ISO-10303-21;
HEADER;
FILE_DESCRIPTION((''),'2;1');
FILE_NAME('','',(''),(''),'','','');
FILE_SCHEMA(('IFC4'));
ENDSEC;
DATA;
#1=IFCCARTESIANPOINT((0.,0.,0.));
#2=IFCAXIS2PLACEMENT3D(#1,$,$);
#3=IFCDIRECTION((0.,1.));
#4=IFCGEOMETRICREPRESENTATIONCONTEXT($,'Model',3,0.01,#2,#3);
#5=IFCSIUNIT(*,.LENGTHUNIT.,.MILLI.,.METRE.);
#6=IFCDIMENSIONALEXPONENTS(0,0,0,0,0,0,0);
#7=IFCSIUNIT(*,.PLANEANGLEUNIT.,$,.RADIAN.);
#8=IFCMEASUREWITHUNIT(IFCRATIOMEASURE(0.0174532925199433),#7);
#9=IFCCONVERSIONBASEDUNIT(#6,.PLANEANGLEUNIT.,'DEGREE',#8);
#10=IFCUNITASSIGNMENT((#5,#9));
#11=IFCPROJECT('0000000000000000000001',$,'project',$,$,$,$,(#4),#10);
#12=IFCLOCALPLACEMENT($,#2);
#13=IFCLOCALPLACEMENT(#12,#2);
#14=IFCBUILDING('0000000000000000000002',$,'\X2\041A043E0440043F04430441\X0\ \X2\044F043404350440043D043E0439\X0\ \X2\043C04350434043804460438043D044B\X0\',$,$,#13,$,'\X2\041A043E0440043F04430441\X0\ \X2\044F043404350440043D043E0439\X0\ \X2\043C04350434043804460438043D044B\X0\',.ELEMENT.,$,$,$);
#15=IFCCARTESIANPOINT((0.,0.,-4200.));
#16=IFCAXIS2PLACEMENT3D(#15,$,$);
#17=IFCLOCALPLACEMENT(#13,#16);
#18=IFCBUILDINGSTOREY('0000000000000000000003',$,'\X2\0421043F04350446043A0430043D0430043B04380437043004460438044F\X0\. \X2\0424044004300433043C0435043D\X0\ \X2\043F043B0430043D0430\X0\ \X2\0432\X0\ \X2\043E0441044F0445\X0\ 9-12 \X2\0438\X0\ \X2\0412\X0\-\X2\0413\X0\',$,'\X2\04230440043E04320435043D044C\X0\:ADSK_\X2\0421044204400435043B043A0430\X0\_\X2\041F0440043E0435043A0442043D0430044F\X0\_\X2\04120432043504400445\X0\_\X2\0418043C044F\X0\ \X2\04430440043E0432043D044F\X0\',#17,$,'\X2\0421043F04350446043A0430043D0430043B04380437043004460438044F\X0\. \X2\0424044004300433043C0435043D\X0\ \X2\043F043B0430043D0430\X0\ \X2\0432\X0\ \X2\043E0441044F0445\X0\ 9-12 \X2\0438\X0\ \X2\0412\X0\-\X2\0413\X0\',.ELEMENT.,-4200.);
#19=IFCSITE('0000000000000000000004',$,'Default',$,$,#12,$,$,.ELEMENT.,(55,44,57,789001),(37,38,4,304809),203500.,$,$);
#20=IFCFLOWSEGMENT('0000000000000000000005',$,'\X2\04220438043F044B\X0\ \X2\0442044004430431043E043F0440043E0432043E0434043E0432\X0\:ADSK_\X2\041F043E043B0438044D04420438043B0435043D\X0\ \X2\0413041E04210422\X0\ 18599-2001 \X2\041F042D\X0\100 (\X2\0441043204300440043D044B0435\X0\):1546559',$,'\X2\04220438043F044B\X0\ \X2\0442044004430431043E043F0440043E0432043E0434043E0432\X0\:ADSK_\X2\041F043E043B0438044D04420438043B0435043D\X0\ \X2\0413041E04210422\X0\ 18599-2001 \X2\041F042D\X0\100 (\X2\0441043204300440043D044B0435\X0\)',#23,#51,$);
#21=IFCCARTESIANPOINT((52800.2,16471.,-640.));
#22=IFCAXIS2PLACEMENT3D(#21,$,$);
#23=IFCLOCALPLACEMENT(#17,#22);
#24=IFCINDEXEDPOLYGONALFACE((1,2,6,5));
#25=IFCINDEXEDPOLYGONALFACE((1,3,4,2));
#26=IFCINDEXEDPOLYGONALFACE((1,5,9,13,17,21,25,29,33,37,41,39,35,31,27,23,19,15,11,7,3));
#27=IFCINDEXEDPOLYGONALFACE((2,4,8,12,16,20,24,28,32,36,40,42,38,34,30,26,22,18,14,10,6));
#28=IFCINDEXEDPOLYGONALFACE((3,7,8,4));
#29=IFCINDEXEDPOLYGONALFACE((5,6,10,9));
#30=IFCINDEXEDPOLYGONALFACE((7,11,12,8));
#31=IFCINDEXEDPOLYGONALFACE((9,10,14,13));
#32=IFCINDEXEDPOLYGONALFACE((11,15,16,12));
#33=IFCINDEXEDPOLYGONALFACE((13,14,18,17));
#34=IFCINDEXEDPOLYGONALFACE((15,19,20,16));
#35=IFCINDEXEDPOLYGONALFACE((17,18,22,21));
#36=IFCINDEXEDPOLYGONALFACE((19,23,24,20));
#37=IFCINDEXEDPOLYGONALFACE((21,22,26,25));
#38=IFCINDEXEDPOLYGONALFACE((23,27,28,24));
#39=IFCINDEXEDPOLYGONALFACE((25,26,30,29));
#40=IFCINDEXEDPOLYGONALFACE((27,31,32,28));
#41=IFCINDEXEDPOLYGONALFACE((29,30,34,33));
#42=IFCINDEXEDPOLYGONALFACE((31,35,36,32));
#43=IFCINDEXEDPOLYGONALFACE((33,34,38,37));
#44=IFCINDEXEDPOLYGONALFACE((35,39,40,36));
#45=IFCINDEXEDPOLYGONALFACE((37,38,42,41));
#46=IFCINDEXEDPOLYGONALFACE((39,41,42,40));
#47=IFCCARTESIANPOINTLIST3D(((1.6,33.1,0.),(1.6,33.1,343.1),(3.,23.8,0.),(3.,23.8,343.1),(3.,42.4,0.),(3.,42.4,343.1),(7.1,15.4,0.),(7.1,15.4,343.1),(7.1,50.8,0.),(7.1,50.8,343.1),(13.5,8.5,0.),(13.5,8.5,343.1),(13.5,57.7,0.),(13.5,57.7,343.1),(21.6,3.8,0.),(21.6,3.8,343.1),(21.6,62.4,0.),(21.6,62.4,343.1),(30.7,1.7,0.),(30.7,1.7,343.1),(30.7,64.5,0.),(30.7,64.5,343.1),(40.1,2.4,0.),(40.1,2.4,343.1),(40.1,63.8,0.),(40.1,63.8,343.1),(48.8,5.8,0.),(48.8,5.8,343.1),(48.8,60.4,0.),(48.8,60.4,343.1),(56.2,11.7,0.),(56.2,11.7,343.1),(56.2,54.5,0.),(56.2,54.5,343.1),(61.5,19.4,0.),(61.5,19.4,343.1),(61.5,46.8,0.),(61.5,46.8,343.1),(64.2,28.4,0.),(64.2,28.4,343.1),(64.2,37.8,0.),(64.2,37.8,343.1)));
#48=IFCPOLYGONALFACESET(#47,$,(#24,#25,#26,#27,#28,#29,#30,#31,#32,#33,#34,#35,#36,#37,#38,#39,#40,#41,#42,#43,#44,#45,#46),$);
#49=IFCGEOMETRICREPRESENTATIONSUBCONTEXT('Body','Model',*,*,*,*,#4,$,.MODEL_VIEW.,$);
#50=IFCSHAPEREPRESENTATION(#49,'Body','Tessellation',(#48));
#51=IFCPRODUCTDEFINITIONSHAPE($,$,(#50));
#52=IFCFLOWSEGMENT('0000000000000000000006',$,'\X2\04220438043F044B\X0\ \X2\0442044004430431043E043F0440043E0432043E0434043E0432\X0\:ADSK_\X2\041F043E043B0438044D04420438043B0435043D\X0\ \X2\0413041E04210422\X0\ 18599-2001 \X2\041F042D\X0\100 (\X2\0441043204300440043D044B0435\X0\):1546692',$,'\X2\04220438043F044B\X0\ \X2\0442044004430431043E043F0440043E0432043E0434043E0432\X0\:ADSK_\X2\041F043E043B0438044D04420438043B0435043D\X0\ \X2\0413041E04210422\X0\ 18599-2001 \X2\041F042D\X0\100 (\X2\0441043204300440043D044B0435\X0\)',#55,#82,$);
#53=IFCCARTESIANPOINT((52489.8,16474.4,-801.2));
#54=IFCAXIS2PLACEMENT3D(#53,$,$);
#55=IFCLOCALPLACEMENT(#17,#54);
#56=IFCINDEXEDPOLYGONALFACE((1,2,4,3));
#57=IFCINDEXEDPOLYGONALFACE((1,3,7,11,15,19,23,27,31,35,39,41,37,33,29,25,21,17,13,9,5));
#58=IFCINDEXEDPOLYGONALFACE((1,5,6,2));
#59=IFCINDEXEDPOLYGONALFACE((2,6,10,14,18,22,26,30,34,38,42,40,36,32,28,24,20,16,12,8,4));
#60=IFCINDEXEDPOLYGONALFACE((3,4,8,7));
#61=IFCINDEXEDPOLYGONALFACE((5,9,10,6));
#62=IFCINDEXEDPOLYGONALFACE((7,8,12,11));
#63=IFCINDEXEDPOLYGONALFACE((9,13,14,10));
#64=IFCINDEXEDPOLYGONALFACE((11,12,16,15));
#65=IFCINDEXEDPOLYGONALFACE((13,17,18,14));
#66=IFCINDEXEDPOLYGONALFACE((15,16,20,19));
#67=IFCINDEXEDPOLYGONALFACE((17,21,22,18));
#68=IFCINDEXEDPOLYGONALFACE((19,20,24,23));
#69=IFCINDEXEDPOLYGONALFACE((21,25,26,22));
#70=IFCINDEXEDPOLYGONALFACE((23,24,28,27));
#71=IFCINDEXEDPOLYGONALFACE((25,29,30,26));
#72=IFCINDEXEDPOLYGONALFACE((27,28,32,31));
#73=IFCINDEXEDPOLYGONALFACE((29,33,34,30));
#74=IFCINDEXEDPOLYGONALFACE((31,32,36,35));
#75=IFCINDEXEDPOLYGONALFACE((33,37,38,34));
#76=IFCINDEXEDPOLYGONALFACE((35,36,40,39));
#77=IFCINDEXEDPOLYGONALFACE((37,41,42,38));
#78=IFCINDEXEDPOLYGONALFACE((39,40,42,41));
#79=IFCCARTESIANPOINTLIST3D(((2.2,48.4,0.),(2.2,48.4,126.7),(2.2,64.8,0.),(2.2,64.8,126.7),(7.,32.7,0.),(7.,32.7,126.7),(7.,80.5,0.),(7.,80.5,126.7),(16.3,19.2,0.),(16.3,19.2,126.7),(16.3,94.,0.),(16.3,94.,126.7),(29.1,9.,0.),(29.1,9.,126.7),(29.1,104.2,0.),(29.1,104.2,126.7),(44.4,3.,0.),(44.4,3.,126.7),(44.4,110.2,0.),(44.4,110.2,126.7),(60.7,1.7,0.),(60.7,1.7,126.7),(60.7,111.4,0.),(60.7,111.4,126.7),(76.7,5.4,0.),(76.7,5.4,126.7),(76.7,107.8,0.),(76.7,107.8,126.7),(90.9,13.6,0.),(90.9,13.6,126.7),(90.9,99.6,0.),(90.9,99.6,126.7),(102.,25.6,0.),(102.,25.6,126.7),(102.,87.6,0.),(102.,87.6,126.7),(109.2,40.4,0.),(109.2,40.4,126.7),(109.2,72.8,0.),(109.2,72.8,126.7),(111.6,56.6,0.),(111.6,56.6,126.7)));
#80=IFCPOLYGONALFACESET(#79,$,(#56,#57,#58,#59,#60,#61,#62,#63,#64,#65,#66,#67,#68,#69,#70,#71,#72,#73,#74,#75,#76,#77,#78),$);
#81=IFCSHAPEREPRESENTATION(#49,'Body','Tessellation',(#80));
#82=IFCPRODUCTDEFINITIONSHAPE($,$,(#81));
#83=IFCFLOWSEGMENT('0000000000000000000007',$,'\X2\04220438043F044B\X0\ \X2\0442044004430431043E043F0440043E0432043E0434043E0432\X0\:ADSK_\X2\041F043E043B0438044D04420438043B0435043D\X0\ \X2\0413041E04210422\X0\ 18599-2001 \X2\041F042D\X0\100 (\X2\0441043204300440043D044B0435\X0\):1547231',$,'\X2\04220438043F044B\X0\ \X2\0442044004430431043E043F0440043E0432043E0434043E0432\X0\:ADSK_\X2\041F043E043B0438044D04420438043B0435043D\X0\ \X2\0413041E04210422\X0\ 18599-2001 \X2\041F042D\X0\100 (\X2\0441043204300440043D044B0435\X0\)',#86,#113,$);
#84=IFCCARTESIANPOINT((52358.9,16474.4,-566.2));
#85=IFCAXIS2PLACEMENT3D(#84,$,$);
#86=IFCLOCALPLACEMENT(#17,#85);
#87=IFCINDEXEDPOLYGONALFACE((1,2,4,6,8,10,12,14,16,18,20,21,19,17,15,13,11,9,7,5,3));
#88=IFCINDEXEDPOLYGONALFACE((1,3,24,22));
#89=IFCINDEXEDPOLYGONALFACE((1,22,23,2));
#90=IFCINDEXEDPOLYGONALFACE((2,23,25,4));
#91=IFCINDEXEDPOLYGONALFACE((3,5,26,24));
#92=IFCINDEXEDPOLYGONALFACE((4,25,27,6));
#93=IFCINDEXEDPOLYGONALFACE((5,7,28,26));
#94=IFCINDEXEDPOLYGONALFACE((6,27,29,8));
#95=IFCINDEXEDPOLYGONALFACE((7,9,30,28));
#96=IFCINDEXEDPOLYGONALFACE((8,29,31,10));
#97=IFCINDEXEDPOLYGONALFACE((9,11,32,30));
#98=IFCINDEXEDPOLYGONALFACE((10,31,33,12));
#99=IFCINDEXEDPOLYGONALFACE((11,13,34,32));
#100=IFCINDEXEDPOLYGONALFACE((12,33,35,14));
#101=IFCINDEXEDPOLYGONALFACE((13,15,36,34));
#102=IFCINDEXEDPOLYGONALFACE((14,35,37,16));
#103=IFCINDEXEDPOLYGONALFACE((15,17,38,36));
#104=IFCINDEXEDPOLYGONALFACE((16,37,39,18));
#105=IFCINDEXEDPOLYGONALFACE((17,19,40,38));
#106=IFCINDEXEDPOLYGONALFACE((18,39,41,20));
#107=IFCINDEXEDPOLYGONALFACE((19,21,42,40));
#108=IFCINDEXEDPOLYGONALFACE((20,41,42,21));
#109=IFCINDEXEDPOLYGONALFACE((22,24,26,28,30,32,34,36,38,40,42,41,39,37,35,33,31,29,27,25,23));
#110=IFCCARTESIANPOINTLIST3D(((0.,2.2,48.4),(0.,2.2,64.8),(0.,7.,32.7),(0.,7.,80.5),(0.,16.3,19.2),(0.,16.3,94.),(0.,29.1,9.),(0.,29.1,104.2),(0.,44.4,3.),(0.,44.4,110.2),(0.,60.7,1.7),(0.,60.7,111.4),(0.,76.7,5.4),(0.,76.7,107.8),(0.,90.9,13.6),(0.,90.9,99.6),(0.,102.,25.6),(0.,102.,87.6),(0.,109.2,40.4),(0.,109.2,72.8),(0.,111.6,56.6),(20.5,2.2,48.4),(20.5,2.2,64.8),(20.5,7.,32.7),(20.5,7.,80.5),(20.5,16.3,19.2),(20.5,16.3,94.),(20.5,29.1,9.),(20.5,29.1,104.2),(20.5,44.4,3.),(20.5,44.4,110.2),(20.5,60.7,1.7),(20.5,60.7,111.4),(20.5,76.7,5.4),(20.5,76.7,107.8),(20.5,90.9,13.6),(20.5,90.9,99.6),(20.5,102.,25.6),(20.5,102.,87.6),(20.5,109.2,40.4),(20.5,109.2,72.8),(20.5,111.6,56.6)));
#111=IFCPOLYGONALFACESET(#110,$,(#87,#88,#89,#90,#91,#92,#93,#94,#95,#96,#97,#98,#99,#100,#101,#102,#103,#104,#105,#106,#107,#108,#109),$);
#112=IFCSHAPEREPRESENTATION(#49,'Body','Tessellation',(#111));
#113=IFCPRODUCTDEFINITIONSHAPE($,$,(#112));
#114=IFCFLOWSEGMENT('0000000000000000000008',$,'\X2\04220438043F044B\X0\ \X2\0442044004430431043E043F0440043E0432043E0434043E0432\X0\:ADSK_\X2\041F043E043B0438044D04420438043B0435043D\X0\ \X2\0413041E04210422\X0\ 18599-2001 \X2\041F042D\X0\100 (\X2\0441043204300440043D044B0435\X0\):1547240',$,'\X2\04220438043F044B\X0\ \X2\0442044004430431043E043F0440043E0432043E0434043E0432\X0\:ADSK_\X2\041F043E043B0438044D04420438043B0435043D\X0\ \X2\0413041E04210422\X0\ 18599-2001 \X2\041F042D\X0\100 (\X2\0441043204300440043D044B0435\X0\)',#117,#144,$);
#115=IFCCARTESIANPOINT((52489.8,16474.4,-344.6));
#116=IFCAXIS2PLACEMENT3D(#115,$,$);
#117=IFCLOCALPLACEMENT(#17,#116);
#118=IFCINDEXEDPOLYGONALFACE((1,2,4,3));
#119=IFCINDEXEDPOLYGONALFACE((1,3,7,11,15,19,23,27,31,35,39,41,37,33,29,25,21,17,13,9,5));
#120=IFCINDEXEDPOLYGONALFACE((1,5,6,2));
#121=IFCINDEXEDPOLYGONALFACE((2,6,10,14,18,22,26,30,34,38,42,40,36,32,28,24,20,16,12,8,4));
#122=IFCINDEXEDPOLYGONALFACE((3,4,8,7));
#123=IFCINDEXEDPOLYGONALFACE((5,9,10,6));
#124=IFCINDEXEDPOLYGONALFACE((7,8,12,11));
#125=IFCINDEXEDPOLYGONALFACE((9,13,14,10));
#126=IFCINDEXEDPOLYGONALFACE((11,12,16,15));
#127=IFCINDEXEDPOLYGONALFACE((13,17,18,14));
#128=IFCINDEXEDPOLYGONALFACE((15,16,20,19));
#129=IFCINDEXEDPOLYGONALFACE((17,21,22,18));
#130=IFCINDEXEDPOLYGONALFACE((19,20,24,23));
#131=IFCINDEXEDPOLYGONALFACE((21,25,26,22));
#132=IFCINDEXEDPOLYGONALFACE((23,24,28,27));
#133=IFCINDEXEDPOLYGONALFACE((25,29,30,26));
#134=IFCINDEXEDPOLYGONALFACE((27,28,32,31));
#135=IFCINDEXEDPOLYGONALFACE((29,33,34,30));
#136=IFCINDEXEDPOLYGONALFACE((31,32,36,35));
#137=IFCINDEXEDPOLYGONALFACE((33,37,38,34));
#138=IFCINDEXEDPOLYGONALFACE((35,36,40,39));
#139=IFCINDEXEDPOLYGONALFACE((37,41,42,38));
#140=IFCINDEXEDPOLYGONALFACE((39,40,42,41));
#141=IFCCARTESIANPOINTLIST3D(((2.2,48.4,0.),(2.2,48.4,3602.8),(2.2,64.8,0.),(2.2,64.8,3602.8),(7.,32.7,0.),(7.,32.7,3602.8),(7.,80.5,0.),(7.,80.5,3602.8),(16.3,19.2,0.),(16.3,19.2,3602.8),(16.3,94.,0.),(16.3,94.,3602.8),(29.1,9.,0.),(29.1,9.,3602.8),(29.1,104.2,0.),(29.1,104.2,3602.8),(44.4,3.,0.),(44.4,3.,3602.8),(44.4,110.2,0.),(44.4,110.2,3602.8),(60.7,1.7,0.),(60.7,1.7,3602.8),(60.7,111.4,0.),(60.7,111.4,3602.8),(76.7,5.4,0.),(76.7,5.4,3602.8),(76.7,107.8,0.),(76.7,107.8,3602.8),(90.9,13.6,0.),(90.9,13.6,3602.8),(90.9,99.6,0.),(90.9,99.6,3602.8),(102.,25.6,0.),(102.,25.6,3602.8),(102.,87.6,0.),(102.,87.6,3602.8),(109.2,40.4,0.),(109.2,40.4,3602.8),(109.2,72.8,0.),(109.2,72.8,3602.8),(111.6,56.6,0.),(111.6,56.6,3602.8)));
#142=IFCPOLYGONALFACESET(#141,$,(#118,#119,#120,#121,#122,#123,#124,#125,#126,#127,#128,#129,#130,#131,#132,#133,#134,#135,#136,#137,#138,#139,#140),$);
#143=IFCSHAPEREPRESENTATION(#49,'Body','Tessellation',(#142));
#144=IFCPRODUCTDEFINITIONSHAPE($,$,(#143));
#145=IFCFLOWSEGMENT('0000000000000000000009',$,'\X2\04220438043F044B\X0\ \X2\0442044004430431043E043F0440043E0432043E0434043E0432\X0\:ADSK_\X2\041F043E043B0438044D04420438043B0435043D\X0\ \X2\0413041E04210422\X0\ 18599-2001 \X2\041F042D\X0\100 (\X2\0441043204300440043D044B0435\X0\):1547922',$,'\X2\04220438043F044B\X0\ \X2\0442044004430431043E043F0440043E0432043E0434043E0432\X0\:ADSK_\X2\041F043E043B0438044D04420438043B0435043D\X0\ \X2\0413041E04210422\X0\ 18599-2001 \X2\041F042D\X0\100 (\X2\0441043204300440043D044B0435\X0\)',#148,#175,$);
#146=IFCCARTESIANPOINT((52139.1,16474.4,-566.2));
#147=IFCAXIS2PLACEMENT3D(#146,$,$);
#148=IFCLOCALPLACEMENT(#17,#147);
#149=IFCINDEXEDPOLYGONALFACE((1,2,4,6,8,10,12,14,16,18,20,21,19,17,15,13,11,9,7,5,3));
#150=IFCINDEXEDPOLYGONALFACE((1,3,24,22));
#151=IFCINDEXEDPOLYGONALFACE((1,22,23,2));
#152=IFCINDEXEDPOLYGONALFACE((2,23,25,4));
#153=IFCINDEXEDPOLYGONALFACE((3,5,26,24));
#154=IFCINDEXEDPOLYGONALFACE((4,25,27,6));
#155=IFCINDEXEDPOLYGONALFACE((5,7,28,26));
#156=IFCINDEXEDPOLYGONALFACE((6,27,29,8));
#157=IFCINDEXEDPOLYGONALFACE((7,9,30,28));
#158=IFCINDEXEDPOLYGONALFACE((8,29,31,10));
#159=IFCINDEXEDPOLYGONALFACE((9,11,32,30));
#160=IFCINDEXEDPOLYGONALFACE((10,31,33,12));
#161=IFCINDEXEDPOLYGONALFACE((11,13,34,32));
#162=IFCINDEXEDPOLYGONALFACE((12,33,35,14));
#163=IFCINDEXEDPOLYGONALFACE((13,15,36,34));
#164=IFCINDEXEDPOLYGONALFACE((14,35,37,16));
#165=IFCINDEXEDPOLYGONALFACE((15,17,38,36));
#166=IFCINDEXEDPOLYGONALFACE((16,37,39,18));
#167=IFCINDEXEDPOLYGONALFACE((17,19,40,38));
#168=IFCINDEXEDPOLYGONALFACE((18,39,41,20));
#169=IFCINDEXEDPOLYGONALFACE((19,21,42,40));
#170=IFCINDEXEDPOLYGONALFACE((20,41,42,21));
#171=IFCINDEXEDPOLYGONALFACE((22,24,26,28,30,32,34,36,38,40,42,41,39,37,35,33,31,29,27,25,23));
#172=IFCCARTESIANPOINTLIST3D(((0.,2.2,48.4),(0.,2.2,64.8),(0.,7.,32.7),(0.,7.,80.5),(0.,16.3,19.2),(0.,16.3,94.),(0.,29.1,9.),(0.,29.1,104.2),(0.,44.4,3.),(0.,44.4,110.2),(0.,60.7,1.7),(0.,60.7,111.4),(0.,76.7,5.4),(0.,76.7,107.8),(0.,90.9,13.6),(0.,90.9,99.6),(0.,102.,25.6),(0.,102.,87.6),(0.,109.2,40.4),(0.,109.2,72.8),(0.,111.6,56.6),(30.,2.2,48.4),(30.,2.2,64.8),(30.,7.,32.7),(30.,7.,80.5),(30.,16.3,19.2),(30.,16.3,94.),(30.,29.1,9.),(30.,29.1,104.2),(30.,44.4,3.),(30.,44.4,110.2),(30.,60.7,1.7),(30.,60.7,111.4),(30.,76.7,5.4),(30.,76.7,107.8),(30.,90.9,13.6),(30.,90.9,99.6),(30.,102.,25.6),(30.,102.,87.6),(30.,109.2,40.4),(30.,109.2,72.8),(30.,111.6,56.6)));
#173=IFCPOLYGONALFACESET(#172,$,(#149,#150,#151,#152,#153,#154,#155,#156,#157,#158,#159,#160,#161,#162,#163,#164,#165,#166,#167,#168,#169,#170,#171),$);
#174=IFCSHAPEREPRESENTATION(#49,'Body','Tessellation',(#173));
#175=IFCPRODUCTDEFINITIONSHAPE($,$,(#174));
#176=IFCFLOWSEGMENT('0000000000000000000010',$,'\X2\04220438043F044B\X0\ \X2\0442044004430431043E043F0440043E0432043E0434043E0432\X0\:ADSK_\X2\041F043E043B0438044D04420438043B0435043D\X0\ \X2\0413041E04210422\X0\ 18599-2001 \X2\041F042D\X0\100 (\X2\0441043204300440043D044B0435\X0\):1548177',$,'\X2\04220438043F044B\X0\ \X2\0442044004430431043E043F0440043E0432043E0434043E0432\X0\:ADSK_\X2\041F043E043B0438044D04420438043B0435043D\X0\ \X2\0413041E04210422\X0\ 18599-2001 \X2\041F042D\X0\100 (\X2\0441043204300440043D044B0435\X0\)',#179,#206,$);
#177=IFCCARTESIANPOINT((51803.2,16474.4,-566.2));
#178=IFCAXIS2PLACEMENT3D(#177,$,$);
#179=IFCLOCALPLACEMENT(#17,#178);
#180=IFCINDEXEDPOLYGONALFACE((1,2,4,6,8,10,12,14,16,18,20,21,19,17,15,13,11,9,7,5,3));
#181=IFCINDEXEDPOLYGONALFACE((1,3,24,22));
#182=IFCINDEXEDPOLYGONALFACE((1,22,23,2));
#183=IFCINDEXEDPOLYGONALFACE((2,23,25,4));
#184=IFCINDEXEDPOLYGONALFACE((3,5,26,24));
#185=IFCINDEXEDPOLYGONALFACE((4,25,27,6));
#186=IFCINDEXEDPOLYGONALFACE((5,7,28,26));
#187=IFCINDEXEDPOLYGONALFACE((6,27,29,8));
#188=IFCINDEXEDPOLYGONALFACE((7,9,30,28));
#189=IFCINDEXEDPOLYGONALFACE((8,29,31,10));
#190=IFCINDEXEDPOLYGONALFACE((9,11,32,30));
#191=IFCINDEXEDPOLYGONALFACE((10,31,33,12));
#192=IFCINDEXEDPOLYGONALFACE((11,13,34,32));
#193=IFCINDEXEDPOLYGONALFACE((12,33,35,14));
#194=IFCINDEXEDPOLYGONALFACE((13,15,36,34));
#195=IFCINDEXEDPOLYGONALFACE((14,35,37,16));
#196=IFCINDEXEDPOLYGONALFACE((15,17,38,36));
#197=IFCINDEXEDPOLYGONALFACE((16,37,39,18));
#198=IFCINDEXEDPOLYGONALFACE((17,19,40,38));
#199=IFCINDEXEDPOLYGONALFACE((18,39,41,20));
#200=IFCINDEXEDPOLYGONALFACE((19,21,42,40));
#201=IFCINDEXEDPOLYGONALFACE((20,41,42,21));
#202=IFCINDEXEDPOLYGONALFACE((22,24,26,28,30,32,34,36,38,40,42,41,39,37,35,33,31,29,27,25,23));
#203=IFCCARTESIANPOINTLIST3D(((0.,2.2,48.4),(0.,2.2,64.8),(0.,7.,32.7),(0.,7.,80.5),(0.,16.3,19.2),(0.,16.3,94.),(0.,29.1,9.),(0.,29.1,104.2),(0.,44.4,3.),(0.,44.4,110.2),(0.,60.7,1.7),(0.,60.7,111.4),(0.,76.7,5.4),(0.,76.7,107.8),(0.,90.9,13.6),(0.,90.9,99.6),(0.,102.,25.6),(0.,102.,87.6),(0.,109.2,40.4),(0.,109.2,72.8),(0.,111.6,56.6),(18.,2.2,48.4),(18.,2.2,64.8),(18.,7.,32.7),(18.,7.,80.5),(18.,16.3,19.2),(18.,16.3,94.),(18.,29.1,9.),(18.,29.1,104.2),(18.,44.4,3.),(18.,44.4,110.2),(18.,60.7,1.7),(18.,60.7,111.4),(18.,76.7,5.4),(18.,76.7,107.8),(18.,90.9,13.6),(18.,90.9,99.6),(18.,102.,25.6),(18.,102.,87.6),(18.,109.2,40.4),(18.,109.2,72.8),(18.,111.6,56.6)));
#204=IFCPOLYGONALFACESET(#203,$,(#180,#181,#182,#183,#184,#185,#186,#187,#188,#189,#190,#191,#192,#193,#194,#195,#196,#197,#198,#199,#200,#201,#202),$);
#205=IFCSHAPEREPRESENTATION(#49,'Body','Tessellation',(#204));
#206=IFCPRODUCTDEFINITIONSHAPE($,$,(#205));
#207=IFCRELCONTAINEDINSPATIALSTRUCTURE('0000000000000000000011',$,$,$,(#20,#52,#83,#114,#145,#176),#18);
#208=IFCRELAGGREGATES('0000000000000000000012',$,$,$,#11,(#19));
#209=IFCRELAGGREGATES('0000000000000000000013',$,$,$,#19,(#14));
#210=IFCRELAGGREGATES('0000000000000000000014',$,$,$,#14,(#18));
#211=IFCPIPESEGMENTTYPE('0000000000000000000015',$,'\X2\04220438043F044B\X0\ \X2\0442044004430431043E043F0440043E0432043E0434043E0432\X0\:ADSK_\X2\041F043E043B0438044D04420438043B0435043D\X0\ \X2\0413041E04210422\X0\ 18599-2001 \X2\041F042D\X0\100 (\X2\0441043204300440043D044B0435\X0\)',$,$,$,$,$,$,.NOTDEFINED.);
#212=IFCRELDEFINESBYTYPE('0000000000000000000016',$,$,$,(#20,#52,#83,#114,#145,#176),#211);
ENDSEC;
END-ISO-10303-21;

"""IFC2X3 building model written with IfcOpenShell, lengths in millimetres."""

from ifc_helpers import new_model, entity, si_unit, converted_unit, direction, frame, frame_2d, origin, origin_2d_with_axis, place, context, subcontext, project, spatial, circle, extrude, type_object, element, save


model = new_model("IFC2X3")

# Units and contexts
model_context = context("Model", 3, precision=0.01, world=origin(), true_north=direction((0.0, 1.0)))
body_context = subcontext(model_context, "Body", "Model", "MODEL_VIEW")
ifc_project = project(units=[si_unit("LENGTHUNIT", "METRE", prefix="MILLI"), converted_unit("PLANEANGLEUNIT", "DEGREE", entity("IfcRatioMeasure", 0.0174532925199433), si_unit("PLANEANGLEUNIT", "RADIAN"), dimensions=[0, 0, 0, 0, 0, 0, 0])], contexts=[model_context])

# Site, building, storey
site_placement = place(None, frame((0.0, 0.0, 0.0)))
site = spatial("IfcSite", under=ifc_project, at=site_placement, Name="Default", CompositionType="ELEMENT", RefLatitude=(55, 44, 57, 789001), RefLongitude=(37, 38, 4, 304809), RefElevation=203500.0)
building_placement = place(site_placement, origin())
building = spatial("IfcBuilding", under=site, at=building_placement, Name="Корпус ядерной медицины", LongName="Корпус ядерной медицины", CompositionType="ELEMENT")
storey_placement = place(building_placement, frame((0.0, 0.0, -4200.0)))
storey = spatial("IfcBuildingStorey", under=building, at=storey_placement, Name="Спецканализация. Фрагмен плана в осях 9-12 и В-Г", ObjectType="Уровень:ADSK_Стрелка_Проектная_Вверх_Имя уровня", LongName="Спецканализация. Фрагмен плана в осях 9-12 и В-Г", CompositionType="ELEMENT", Elevation=-4200.0)

# Flow segments
pipe_segment_type = type_object("IfcPipeSegmentType", Name="Типы трубопроводов:ADSK_Полиэтилен ГОСТ 18599-2001 ПЭ100 (сварные)", PredefinedType="NOTDEFINED")
flow_segment_1_placement = place(storey_placement, frame((52800.2, 16471.0, -640.0)))
element("IfcFlowSegment", 1, at=flow_segment_1_placement, inside=storey, type_object=pipe_segment_type, Name="Типы трубопроводов:ADSK_Полиэтилен ГОСТ 18599-2001 ПЭ100 (сварные):1546559", ObjectType="Типы трубопроводов:ADSK_Полиэтилен ГОСТ 18599-2001 ПЭ100 (сварные)", context=body_context, shape_type="SweptSolid", body=[
    extrude(circle(Radius=31.5, at=frame_2d((0.0, 0.0), x_axis=(1.0, 0.0))), frame((33.1, 33.1, 0.0), z_axis=(0.0, 0.0, 1.0), x_axis=(-1.0, 0.0, 0.0)), (0.0, 0.0, 1.0), 343.1),
])
flow_segment_2_placement = place(storey_placement, frame((52489.8, 16474.4, -801.2)))
element("IfcFlowSegment", 2, at=flow_segment_2_placement, inside=storey, type_object=pipe_segment_type, Name="Типы трубопроводов:ADSK_Полиэтилен ГОСТ 18599-2001 ПЭ100 (сварные):1546692", ObjectType="Типы трубопроводов:ADSK_Полиэтилен ГОСТ 18599-2001 ПЭ100 (сварные)", context=body_context, shape_type="SweptSolid", body=[
    extrude(circle(Radius=55.0, at=origin_2d_with_axis()), frame((56.6, 56.6, 0.0)), (0.0, 0.0, 1.0), 126.7),
])
flow_segment_3_placement = place(storey_placement, frame((52358.9, 16474.4, -566.2)))
element("IfcFlowSegment", 3, at=flow_segment_3_placement, inside=storey, type_object=pipe_segment_type, Name="Типы трубопроводов:ADSK_Полиэтилен ГОСТ 18599-2001 ПЭ100 (сварные):1547231", ObjectType="Типы трубопроводов:ADSK_Полиэтилен ГОСТ 18599-2001 ПЭ100 (сварные)", context=body_context, shape_type="SweptSolid", body=[
    extrude(circle(Radius=55.0, at=frame_2d((0.0, 0.0), x_axis=(1.0, 0.0))), frame((0.0, 56.6, 56.6), z_axis=(1.0, 0.0, 0.0), x_axis=(0.0, 1.0, 0.0)), (0.0, 0.0, 1.0), 20.5),
])
flow_segment_4_placement = place(storey_placement, frame((52489.8, 16474.4, -344.6)))
element("IfcFlowSegment", 4, at=flow_segment_4_placement, inside=storey, type_object=pipe_segment_type, Name="Типы трубопроводов:ADSK_Полиэтилен ГОСТ 18599-2001 ПЭ100 (сварные):1547240", ObjectType="Типы трубопроводов:ADSK_Полиэтилен ГОСТ 18599-2001 ПЭ100 (сварные)", context=body_context, shape_type="SweptSolid", body=[
    extrude(circle(Radius=55.0, at=origin_2d_with_axis()), frame((56.6, 56.6, 0.0)), (0.0, 0.0, 1.0), 3602.8),
])
flow_segment_5_placement = place(storey_placement, frame((52139.1, 16474.4, -566.2)))
element("IfcFlowSegment", 5, at=flow_segment_5_placement, inside=storey, type_object=pipe_segment_type, Name="Типы трубопроводов:ADSK_Полиэтилен ГОСТ 18599-2001 ПЭ100 (сварные):1547922", ObjectType="Типы трубопроводов:ADSK_Полиэтилен ГОСТ 18599-2001 ПЭ100 (сварные)", context=body_context, shape_type="SweptSolid", body=[
    extrude(circle(Radius=55.0, at=origin_2d_with_axis()), frame((0.0, 56.6, 56.6), z_axis=(1.0, 0.0, 0.0), x_axis=(0.0, 1.0, 0.0)), (0.0, 0.0, 1.0), 30.0),
])
flow_segment_6_placement = place(storey_placement, frame((51803.2, 16474.4, -566.2)))
element("IfcFlowSegment", 6, at=flow_segment_6_placement, inside=storey, type_object=pipe_segment_type, Name="Типы трубопроводов:ADSK_Полиэтилен ГОСТ 18599-2001 ПЭ100 (сварные):1548177", ObjectType="Типы трубопроводов:ADSK_Полиэтилен ГОСТ 18599-2001 ПЭ100 (сварные)", context=body_context, shape_type="SweptSolid", body=[
    extrude(circle(Radius=55.0, at=origin_2d_with_axis()), frame((0.0, 56.6, 56.6), z_axis=(1.0, 0.0, 0.0), x_axis=(0.0, 1.0, 0.0)), (0.0, 0.0, 1.0), 18.0),
])

save(model, "model.ifc")
